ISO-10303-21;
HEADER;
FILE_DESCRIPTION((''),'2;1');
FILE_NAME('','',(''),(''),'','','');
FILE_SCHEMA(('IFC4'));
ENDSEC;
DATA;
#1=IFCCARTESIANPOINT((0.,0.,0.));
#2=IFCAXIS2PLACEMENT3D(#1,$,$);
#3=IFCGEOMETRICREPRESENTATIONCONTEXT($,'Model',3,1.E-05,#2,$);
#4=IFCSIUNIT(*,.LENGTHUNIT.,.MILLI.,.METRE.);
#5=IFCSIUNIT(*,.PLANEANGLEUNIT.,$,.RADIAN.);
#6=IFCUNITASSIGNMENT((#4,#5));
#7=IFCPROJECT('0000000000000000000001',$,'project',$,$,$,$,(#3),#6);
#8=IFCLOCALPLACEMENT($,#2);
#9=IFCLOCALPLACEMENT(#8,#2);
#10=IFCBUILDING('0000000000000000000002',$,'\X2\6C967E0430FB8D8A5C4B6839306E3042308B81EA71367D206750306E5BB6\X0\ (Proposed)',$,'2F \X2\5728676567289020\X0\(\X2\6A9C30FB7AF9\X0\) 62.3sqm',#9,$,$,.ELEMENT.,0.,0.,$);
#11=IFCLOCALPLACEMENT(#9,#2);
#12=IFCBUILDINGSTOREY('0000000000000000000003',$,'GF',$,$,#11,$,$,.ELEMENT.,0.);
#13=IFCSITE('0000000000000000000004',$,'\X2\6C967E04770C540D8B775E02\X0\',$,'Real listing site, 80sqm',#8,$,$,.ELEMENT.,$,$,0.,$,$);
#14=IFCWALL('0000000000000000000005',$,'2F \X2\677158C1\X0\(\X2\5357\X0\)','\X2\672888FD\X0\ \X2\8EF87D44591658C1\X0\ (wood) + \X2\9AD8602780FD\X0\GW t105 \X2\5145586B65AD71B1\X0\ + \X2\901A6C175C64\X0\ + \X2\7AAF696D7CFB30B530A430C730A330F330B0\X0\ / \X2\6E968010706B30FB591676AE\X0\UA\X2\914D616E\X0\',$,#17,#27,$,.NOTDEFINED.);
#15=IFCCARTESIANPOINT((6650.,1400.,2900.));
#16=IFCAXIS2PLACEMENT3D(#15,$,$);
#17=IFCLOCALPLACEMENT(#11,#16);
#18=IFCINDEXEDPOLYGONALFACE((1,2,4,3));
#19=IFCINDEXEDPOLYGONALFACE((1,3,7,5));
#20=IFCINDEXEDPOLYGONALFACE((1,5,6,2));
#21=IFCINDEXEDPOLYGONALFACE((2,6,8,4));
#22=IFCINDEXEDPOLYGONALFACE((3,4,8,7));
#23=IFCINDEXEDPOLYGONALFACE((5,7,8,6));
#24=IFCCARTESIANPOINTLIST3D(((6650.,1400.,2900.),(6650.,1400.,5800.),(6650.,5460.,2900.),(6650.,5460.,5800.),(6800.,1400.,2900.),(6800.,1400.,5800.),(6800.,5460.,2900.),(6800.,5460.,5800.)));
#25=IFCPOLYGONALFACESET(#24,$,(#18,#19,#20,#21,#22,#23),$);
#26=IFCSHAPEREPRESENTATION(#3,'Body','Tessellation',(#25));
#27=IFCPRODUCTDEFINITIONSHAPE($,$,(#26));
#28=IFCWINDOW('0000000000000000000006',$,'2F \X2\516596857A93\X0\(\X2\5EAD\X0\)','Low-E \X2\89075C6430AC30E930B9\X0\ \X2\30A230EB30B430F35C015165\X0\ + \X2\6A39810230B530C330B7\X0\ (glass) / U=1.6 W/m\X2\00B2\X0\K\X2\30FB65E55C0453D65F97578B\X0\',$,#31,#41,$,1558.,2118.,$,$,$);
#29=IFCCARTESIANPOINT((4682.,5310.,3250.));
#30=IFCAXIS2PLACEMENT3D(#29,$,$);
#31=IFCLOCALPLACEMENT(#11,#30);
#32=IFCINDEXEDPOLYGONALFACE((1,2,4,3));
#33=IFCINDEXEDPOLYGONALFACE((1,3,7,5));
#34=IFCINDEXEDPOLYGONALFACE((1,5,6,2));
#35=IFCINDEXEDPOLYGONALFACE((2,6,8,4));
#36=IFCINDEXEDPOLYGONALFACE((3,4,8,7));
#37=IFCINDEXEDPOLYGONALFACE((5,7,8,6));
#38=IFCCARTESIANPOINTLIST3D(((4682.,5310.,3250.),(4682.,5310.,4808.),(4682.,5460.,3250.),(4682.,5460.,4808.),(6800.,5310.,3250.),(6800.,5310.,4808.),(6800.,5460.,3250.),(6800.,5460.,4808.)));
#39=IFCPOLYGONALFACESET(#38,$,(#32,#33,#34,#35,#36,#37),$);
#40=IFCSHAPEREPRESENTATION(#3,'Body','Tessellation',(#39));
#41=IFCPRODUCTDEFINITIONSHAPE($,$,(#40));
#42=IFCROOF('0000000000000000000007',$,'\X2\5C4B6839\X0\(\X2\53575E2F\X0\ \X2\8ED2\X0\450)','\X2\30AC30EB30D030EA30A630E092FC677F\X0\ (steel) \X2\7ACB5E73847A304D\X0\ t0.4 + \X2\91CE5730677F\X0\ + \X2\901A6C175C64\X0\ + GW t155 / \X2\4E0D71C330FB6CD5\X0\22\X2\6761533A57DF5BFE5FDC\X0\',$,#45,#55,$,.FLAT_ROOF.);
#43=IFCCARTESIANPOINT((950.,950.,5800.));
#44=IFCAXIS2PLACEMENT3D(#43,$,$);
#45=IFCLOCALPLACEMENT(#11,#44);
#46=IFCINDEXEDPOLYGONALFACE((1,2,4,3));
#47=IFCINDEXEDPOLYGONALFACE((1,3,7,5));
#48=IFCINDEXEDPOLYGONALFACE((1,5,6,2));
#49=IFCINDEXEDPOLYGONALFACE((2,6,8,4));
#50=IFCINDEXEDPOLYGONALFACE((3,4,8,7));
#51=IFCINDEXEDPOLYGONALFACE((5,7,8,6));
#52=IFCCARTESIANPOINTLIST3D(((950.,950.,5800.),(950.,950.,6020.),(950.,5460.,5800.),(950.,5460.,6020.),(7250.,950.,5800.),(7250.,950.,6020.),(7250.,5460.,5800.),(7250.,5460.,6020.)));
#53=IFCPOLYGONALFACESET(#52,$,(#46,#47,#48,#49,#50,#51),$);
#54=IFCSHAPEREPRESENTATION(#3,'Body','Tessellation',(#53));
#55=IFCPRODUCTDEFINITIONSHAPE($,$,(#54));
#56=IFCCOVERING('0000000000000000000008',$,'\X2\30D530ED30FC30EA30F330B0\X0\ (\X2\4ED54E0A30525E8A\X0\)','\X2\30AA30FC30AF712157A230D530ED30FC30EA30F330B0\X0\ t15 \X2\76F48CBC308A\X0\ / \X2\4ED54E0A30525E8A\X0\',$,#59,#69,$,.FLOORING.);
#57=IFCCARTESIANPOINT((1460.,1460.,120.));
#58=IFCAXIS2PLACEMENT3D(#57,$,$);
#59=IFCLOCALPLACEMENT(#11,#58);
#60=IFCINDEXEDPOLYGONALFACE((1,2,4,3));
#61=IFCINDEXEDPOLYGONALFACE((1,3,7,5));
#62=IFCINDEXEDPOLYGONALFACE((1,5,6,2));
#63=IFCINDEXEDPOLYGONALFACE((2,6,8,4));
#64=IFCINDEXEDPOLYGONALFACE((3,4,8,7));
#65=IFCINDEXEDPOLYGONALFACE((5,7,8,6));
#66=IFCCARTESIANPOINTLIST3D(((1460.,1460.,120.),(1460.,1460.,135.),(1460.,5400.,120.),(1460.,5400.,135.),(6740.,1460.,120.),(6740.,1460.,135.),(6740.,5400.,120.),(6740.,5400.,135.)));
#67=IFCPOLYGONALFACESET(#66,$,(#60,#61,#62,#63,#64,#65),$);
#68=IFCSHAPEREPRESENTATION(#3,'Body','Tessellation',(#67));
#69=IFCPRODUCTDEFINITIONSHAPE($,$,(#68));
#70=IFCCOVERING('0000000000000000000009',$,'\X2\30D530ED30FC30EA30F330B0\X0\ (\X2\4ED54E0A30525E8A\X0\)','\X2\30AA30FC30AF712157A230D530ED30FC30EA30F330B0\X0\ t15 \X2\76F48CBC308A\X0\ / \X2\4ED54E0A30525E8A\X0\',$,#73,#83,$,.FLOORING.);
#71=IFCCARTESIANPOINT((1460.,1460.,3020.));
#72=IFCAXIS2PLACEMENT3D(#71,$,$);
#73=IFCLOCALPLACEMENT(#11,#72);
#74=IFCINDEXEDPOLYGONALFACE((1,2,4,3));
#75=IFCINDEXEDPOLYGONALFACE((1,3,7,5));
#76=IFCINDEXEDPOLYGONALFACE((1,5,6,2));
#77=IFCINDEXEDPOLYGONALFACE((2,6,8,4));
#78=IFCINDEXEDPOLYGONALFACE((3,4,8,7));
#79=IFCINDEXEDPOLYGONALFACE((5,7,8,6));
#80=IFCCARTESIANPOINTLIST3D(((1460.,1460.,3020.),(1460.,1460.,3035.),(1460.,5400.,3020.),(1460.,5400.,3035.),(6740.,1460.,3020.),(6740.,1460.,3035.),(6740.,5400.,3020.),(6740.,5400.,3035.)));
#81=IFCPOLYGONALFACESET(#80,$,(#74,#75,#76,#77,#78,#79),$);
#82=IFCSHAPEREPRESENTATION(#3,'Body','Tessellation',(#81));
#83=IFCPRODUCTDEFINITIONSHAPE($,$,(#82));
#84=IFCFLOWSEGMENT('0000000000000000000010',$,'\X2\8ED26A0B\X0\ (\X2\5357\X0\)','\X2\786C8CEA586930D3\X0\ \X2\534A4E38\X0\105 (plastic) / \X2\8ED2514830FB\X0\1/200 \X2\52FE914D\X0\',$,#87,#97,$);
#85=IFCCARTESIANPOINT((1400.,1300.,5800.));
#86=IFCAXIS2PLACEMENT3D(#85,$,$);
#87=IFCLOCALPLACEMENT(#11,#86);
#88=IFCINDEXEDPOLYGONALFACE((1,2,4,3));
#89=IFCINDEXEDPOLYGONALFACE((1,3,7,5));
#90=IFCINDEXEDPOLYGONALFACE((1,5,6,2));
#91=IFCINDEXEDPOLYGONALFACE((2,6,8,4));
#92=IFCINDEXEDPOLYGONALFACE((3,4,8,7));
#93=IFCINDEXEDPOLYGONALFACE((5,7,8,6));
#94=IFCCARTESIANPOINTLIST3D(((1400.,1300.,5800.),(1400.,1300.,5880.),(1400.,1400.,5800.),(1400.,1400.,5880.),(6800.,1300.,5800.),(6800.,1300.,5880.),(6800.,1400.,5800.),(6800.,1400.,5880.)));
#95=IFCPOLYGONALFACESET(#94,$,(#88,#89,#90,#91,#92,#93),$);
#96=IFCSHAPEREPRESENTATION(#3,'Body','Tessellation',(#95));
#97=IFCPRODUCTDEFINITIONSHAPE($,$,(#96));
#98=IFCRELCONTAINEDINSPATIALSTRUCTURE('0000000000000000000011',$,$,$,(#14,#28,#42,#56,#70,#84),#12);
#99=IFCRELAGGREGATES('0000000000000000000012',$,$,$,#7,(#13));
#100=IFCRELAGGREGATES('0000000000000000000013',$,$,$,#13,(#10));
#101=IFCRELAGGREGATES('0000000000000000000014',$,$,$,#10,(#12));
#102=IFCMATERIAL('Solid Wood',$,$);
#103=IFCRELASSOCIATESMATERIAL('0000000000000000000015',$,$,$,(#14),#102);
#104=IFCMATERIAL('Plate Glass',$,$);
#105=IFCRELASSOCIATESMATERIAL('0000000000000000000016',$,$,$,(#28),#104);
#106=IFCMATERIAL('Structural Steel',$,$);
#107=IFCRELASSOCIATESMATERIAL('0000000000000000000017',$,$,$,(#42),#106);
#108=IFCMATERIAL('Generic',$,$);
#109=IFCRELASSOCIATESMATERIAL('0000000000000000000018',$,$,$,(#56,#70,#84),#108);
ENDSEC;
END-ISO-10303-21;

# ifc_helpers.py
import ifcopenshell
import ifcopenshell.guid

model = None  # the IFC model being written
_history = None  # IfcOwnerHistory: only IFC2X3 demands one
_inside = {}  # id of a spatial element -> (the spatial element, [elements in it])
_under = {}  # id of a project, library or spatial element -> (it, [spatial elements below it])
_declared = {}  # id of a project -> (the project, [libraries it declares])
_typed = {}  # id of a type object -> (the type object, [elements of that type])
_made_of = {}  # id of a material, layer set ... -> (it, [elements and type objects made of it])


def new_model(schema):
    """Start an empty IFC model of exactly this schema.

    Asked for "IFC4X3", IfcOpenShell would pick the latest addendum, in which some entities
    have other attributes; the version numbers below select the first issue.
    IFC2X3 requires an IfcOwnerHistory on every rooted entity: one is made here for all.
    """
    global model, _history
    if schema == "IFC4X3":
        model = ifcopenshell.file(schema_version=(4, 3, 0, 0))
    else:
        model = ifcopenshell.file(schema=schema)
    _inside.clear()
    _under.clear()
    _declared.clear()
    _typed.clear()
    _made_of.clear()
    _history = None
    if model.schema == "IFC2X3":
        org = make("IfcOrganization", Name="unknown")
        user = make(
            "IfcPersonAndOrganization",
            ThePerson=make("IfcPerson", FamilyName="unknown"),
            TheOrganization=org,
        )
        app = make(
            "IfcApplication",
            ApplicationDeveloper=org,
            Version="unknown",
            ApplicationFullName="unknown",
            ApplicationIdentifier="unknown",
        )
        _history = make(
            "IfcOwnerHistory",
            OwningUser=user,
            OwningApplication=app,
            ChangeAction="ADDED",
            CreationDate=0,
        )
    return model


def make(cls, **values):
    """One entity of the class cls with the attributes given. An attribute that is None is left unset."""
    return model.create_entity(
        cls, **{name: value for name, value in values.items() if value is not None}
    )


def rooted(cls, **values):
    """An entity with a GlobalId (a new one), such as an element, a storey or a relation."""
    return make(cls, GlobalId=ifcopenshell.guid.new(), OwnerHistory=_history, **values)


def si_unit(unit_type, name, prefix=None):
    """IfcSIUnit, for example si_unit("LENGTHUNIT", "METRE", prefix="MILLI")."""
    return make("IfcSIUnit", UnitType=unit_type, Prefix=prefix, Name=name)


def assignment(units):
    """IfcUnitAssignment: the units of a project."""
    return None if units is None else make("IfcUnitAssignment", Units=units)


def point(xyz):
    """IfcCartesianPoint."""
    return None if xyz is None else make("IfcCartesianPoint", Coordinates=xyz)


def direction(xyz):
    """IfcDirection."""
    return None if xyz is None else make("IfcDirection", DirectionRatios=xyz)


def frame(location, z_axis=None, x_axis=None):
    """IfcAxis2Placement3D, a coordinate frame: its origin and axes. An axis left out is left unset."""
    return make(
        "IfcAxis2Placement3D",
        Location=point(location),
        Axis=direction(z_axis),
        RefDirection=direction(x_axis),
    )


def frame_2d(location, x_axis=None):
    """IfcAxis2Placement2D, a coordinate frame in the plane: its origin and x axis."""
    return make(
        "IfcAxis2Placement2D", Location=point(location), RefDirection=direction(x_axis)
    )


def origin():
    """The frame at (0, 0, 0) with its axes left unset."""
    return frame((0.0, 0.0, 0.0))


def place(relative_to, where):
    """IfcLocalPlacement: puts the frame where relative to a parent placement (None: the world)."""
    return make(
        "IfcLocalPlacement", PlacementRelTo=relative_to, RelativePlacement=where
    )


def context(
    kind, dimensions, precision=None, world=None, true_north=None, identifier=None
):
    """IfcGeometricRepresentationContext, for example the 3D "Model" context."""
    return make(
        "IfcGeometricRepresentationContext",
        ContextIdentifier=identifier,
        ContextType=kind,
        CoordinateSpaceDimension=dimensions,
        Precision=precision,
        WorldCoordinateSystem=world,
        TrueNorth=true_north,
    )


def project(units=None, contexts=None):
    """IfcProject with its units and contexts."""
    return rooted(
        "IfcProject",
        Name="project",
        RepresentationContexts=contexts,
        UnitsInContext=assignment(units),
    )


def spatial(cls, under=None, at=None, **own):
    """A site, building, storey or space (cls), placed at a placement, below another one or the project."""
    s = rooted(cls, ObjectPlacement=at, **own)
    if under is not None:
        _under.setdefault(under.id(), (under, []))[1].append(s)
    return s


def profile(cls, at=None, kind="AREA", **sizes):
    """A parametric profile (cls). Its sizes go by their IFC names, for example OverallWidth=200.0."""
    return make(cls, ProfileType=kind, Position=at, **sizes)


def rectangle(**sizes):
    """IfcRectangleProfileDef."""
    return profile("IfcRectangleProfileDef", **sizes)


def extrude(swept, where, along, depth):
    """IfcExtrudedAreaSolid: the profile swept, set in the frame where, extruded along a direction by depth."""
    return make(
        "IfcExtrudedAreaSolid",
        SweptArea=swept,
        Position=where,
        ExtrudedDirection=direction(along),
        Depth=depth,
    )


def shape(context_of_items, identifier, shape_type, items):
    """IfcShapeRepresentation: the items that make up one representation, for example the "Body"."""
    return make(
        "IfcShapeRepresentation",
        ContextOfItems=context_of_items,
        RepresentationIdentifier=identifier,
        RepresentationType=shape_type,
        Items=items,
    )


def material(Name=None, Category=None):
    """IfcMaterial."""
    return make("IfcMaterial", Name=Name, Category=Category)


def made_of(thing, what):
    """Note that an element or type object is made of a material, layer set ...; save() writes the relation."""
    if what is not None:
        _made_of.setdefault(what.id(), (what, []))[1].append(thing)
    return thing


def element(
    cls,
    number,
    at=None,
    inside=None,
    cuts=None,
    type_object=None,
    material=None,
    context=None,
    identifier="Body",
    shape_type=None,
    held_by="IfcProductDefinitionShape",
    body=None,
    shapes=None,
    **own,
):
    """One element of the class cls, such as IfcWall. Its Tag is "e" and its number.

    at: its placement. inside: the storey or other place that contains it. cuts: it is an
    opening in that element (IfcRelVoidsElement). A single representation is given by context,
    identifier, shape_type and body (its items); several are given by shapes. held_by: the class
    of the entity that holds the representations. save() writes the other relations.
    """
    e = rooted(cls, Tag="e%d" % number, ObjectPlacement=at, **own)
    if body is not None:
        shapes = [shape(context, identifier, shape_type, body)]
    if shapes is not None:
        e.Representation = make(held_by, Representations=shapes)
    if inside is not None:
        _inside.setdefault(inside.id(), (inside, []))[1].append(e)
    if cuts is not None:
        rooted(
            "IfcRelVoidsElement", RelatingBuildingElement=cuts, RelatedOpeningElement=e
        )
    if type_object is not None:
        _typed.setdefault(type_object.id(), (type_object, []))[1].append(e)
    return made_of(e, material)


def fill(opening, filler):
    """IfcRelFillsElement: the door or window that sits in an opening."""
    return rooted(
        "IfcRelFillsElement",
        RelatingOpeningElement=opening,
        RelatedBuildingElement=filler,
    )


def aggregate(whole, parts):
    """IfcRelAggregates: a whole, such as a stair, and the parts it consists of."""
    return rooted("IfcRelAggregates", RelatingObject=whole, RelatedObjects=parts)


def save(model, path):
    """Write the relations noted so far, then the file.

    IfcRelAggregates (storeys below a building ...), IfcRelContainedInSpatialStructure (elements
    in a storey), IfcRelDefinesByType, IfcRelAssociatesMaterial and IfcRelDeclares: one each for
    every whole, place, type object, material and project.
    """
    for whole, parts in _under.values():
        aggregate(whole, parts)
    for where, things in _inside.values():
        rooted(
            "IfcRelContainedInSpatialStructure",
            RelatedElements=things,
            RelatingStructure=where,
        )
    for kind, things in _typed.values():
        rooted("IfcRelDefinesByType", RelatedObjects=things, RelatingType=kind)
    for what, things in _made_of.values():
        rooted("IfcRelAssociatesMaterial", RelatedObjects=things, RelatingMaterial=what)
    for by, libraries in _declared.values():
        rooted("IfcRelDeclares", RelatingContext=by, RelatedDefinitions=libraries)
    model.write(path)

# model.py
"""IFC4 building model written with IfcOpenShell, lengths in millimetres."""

from ifc_helpers import new_model, si_unit, frame, frame_2d, origin, place, context, project, spatial, rectangle, extrude, material, element, fill, save


model = new_model("IFC4")

# Units and contexts
model_context = context("Model", 3, precision=1e-05, world=origin())
ifc_project = project(units=[si_unit("LENGTHUNIT", "METRE", prefix="MILLI"), si_unit("PLANEANGLEUNIT", "RADIAN")], contexts=[model_context])

# Site, building, storey
site_placement = place(None, origin())
site = spatial("IfcSite", under=ifc_project, at=site_placement, Name="沖縄県名護市", ObjectType="Real listing site, 80sqm", CompositionType="ELEMENT", RefElevation=0.0)
building_placement = place(site_placement, origin())
building = spatial("IfcBuilding", under=site, at=building_placement, Name="沖縄・越屋根のある自然素材の家 (Proposed)", ObjectType="2F 在来木造(檜・竹) 62.3sqm", CompositionType="ELEMENT", ElevationOfRefHeight=0.0, ElevationOfTerrain=0.0)
storey_placement = place(building_placement, origin())
storey = spatial("IfcBuildingStorey", under=building, at=storey_placement, Name="GF", CompositionType="ELEMENT", Elevation=0.0)

# Shared definitions
ifc_material_1 = material(Name="Solid Wood")

# Wall, opening, window
ifc_material_2 = material(Name="Plate Glass")
wall_1_placement = place(storey_placement, frame((6650.0, 1400.0, 2900.0)))
wall_1 = element("IfcWall", 1, at=wall_1_placement, inside=storey, material=ifc_material_1, Name="2F 東壁(南)", Description="木製 軸組外壁 (wood) + 高性能GW t105 充填断熱 + 通気層 + 窯業系サイディング / 準耐火・外皮UA配慮", PredefinedType="NOTDEFINED", context=model_context, shape_type="SweptSolid", body=[
    extrude(rectangle(XDim=150.0, YDim=4060.0, at=frame_2d((75.0, 2030.0))), frame((6650.0, 1400.0, 2900.0)), (0.0, 0.0, 1.0), 2900.0),
])
opening_1_placement = place(storey_placement, frame((4682.0, 5310.0, 3250.0)))
opening_1 = element("IfcOpeningElement", 2, at=opening_1_placement, cuts=wall_1, PredefinedType="NOTDEFINED", context=model_context, shape_type="SweptSolid", body=[
    extrude(rectangle(XDim=2118.0, YDim=150.0, at=frame_2d((1059.0, 75.0))), frame((4682.0, 5310.0, 3250.0)), (0.0, 0.0, 1.0), 1558.0),
])
window_1_placement = place(storey_placement, frame((4682.0, 5310.0, 3250.0)))
window_1 = element("IfcWindow", 3, at=window_1_placement, inside=storey, material=ifc_material_2, Name="2F 入隅窓(庭)", Description="Low-E 複層ガラス アルゴン封入 + 樹脂サッシ (glass) / U=1.6 W/m²K・日射取得型", OverallHeight=1558.0, OverallWidth=2118.0, context=model_context, shape_type="SweptSolid", body=[
    extrude(rectangle(XDim=2118.0, YDim=150.0, at=frame_2d((1059.0, 75.0))), frame((4682.0, 5310.0, 3250.0)), (0.0, 0.0, 1.0), 1558.0),
])
fill(opening_1, window_1)

# Roof
ifc_material_3 = material(Name="Structural Steel")
for number, where, name in (
    (4, (950.0, 950.0, 5800.0), "屋根(南帯 軒450)"),
):
    element("IfcRoof", number, at=place(storey_placement, frame(where)), inside=storey, material=ifc_material_3, Name=name, Description="ガルバリウム鋼板 (steel) 立平葺き t0.4 + 野地板 + 通気層 + GW t155 / 不燃・法22条区域対応", PredefinedType="FLAT_ROOF", context=model_context, shape_type="SweptSolid", body=[
        extrude(rectangle(XDim=6300.0, YDim=4510.0, at=frame_2d((3150.0, 2255.0))), frame((950.0, 950.0, 5800.0)), (0.0, 0.0, 1.0), 220.0),
    ])

# Coverings
ifc_material_4 = material(Name="Generic")
covering_1_placement = place(storey_placement, frame((1460.0, 1460.0, 120.0)))
element("IfcCovering", 5, at=covering_1_placement, inside=storey, material=ifc_material_4, Name="フローリング (仕上げ床)", Description="オーク無垢フローリング t15 直貼り / 仕上げ床", PredefinedType="FLOORING", context=model_context, shape_type="SweptSolid", body=[
    extrude(rectangle(XDim=5280.0, YDim=3940.0, at=frame_2d((2640.0, 1970.0))), frame((1460.0, 1460.0, 120.0)), (0.0, 0.0, 1.0), 15.0),
])
covering_2_placement = place(storey_placement, frame((1460.0, 1460.0, 3020.0)))
element("IfcCovering", 6, at=covering_2_placement, inside=storey, material=ifc_material_4, Name="フローリング (仕上げ床)", Description="オーク無垢フローリング t15 直貼り / 仕上げ床", PredefinedType="FLOORING", context=model_context, shape_type="SweptSolid", body=[
    extrude(rectangle(XDim=5280.0, YDim=3940.0, at=frame_2d((2640.0, 1970.0))), frame((1460.0, 1460.0, 3020.0)), (0.0, 0.0, 1.0), 15.0),
])

# Flow segment
flow_segment_placement = place(storey_placement, frame((1400.0, 1300.0, 5800.0)))
element("IfcFlowSegment", 7, at=flow_segment_placement, inside=storey, material=ifc_material_4, Name="軒樋 (南)", Description="硬質塩ビ 半丸105 (plastic) / 軒先・1/200 勾配", context=model_context, shape_type="SweptSolid", body=[
    extrude(rectangle(XDim=5400.0, YDim=100.0, at=frame_2d((2700.0, 50.0))), frame((1400.0, 1300.0, 5800.0)), (0.0, 0.0, 1.0), 80.0),
])

save(model, "model.ifc")
